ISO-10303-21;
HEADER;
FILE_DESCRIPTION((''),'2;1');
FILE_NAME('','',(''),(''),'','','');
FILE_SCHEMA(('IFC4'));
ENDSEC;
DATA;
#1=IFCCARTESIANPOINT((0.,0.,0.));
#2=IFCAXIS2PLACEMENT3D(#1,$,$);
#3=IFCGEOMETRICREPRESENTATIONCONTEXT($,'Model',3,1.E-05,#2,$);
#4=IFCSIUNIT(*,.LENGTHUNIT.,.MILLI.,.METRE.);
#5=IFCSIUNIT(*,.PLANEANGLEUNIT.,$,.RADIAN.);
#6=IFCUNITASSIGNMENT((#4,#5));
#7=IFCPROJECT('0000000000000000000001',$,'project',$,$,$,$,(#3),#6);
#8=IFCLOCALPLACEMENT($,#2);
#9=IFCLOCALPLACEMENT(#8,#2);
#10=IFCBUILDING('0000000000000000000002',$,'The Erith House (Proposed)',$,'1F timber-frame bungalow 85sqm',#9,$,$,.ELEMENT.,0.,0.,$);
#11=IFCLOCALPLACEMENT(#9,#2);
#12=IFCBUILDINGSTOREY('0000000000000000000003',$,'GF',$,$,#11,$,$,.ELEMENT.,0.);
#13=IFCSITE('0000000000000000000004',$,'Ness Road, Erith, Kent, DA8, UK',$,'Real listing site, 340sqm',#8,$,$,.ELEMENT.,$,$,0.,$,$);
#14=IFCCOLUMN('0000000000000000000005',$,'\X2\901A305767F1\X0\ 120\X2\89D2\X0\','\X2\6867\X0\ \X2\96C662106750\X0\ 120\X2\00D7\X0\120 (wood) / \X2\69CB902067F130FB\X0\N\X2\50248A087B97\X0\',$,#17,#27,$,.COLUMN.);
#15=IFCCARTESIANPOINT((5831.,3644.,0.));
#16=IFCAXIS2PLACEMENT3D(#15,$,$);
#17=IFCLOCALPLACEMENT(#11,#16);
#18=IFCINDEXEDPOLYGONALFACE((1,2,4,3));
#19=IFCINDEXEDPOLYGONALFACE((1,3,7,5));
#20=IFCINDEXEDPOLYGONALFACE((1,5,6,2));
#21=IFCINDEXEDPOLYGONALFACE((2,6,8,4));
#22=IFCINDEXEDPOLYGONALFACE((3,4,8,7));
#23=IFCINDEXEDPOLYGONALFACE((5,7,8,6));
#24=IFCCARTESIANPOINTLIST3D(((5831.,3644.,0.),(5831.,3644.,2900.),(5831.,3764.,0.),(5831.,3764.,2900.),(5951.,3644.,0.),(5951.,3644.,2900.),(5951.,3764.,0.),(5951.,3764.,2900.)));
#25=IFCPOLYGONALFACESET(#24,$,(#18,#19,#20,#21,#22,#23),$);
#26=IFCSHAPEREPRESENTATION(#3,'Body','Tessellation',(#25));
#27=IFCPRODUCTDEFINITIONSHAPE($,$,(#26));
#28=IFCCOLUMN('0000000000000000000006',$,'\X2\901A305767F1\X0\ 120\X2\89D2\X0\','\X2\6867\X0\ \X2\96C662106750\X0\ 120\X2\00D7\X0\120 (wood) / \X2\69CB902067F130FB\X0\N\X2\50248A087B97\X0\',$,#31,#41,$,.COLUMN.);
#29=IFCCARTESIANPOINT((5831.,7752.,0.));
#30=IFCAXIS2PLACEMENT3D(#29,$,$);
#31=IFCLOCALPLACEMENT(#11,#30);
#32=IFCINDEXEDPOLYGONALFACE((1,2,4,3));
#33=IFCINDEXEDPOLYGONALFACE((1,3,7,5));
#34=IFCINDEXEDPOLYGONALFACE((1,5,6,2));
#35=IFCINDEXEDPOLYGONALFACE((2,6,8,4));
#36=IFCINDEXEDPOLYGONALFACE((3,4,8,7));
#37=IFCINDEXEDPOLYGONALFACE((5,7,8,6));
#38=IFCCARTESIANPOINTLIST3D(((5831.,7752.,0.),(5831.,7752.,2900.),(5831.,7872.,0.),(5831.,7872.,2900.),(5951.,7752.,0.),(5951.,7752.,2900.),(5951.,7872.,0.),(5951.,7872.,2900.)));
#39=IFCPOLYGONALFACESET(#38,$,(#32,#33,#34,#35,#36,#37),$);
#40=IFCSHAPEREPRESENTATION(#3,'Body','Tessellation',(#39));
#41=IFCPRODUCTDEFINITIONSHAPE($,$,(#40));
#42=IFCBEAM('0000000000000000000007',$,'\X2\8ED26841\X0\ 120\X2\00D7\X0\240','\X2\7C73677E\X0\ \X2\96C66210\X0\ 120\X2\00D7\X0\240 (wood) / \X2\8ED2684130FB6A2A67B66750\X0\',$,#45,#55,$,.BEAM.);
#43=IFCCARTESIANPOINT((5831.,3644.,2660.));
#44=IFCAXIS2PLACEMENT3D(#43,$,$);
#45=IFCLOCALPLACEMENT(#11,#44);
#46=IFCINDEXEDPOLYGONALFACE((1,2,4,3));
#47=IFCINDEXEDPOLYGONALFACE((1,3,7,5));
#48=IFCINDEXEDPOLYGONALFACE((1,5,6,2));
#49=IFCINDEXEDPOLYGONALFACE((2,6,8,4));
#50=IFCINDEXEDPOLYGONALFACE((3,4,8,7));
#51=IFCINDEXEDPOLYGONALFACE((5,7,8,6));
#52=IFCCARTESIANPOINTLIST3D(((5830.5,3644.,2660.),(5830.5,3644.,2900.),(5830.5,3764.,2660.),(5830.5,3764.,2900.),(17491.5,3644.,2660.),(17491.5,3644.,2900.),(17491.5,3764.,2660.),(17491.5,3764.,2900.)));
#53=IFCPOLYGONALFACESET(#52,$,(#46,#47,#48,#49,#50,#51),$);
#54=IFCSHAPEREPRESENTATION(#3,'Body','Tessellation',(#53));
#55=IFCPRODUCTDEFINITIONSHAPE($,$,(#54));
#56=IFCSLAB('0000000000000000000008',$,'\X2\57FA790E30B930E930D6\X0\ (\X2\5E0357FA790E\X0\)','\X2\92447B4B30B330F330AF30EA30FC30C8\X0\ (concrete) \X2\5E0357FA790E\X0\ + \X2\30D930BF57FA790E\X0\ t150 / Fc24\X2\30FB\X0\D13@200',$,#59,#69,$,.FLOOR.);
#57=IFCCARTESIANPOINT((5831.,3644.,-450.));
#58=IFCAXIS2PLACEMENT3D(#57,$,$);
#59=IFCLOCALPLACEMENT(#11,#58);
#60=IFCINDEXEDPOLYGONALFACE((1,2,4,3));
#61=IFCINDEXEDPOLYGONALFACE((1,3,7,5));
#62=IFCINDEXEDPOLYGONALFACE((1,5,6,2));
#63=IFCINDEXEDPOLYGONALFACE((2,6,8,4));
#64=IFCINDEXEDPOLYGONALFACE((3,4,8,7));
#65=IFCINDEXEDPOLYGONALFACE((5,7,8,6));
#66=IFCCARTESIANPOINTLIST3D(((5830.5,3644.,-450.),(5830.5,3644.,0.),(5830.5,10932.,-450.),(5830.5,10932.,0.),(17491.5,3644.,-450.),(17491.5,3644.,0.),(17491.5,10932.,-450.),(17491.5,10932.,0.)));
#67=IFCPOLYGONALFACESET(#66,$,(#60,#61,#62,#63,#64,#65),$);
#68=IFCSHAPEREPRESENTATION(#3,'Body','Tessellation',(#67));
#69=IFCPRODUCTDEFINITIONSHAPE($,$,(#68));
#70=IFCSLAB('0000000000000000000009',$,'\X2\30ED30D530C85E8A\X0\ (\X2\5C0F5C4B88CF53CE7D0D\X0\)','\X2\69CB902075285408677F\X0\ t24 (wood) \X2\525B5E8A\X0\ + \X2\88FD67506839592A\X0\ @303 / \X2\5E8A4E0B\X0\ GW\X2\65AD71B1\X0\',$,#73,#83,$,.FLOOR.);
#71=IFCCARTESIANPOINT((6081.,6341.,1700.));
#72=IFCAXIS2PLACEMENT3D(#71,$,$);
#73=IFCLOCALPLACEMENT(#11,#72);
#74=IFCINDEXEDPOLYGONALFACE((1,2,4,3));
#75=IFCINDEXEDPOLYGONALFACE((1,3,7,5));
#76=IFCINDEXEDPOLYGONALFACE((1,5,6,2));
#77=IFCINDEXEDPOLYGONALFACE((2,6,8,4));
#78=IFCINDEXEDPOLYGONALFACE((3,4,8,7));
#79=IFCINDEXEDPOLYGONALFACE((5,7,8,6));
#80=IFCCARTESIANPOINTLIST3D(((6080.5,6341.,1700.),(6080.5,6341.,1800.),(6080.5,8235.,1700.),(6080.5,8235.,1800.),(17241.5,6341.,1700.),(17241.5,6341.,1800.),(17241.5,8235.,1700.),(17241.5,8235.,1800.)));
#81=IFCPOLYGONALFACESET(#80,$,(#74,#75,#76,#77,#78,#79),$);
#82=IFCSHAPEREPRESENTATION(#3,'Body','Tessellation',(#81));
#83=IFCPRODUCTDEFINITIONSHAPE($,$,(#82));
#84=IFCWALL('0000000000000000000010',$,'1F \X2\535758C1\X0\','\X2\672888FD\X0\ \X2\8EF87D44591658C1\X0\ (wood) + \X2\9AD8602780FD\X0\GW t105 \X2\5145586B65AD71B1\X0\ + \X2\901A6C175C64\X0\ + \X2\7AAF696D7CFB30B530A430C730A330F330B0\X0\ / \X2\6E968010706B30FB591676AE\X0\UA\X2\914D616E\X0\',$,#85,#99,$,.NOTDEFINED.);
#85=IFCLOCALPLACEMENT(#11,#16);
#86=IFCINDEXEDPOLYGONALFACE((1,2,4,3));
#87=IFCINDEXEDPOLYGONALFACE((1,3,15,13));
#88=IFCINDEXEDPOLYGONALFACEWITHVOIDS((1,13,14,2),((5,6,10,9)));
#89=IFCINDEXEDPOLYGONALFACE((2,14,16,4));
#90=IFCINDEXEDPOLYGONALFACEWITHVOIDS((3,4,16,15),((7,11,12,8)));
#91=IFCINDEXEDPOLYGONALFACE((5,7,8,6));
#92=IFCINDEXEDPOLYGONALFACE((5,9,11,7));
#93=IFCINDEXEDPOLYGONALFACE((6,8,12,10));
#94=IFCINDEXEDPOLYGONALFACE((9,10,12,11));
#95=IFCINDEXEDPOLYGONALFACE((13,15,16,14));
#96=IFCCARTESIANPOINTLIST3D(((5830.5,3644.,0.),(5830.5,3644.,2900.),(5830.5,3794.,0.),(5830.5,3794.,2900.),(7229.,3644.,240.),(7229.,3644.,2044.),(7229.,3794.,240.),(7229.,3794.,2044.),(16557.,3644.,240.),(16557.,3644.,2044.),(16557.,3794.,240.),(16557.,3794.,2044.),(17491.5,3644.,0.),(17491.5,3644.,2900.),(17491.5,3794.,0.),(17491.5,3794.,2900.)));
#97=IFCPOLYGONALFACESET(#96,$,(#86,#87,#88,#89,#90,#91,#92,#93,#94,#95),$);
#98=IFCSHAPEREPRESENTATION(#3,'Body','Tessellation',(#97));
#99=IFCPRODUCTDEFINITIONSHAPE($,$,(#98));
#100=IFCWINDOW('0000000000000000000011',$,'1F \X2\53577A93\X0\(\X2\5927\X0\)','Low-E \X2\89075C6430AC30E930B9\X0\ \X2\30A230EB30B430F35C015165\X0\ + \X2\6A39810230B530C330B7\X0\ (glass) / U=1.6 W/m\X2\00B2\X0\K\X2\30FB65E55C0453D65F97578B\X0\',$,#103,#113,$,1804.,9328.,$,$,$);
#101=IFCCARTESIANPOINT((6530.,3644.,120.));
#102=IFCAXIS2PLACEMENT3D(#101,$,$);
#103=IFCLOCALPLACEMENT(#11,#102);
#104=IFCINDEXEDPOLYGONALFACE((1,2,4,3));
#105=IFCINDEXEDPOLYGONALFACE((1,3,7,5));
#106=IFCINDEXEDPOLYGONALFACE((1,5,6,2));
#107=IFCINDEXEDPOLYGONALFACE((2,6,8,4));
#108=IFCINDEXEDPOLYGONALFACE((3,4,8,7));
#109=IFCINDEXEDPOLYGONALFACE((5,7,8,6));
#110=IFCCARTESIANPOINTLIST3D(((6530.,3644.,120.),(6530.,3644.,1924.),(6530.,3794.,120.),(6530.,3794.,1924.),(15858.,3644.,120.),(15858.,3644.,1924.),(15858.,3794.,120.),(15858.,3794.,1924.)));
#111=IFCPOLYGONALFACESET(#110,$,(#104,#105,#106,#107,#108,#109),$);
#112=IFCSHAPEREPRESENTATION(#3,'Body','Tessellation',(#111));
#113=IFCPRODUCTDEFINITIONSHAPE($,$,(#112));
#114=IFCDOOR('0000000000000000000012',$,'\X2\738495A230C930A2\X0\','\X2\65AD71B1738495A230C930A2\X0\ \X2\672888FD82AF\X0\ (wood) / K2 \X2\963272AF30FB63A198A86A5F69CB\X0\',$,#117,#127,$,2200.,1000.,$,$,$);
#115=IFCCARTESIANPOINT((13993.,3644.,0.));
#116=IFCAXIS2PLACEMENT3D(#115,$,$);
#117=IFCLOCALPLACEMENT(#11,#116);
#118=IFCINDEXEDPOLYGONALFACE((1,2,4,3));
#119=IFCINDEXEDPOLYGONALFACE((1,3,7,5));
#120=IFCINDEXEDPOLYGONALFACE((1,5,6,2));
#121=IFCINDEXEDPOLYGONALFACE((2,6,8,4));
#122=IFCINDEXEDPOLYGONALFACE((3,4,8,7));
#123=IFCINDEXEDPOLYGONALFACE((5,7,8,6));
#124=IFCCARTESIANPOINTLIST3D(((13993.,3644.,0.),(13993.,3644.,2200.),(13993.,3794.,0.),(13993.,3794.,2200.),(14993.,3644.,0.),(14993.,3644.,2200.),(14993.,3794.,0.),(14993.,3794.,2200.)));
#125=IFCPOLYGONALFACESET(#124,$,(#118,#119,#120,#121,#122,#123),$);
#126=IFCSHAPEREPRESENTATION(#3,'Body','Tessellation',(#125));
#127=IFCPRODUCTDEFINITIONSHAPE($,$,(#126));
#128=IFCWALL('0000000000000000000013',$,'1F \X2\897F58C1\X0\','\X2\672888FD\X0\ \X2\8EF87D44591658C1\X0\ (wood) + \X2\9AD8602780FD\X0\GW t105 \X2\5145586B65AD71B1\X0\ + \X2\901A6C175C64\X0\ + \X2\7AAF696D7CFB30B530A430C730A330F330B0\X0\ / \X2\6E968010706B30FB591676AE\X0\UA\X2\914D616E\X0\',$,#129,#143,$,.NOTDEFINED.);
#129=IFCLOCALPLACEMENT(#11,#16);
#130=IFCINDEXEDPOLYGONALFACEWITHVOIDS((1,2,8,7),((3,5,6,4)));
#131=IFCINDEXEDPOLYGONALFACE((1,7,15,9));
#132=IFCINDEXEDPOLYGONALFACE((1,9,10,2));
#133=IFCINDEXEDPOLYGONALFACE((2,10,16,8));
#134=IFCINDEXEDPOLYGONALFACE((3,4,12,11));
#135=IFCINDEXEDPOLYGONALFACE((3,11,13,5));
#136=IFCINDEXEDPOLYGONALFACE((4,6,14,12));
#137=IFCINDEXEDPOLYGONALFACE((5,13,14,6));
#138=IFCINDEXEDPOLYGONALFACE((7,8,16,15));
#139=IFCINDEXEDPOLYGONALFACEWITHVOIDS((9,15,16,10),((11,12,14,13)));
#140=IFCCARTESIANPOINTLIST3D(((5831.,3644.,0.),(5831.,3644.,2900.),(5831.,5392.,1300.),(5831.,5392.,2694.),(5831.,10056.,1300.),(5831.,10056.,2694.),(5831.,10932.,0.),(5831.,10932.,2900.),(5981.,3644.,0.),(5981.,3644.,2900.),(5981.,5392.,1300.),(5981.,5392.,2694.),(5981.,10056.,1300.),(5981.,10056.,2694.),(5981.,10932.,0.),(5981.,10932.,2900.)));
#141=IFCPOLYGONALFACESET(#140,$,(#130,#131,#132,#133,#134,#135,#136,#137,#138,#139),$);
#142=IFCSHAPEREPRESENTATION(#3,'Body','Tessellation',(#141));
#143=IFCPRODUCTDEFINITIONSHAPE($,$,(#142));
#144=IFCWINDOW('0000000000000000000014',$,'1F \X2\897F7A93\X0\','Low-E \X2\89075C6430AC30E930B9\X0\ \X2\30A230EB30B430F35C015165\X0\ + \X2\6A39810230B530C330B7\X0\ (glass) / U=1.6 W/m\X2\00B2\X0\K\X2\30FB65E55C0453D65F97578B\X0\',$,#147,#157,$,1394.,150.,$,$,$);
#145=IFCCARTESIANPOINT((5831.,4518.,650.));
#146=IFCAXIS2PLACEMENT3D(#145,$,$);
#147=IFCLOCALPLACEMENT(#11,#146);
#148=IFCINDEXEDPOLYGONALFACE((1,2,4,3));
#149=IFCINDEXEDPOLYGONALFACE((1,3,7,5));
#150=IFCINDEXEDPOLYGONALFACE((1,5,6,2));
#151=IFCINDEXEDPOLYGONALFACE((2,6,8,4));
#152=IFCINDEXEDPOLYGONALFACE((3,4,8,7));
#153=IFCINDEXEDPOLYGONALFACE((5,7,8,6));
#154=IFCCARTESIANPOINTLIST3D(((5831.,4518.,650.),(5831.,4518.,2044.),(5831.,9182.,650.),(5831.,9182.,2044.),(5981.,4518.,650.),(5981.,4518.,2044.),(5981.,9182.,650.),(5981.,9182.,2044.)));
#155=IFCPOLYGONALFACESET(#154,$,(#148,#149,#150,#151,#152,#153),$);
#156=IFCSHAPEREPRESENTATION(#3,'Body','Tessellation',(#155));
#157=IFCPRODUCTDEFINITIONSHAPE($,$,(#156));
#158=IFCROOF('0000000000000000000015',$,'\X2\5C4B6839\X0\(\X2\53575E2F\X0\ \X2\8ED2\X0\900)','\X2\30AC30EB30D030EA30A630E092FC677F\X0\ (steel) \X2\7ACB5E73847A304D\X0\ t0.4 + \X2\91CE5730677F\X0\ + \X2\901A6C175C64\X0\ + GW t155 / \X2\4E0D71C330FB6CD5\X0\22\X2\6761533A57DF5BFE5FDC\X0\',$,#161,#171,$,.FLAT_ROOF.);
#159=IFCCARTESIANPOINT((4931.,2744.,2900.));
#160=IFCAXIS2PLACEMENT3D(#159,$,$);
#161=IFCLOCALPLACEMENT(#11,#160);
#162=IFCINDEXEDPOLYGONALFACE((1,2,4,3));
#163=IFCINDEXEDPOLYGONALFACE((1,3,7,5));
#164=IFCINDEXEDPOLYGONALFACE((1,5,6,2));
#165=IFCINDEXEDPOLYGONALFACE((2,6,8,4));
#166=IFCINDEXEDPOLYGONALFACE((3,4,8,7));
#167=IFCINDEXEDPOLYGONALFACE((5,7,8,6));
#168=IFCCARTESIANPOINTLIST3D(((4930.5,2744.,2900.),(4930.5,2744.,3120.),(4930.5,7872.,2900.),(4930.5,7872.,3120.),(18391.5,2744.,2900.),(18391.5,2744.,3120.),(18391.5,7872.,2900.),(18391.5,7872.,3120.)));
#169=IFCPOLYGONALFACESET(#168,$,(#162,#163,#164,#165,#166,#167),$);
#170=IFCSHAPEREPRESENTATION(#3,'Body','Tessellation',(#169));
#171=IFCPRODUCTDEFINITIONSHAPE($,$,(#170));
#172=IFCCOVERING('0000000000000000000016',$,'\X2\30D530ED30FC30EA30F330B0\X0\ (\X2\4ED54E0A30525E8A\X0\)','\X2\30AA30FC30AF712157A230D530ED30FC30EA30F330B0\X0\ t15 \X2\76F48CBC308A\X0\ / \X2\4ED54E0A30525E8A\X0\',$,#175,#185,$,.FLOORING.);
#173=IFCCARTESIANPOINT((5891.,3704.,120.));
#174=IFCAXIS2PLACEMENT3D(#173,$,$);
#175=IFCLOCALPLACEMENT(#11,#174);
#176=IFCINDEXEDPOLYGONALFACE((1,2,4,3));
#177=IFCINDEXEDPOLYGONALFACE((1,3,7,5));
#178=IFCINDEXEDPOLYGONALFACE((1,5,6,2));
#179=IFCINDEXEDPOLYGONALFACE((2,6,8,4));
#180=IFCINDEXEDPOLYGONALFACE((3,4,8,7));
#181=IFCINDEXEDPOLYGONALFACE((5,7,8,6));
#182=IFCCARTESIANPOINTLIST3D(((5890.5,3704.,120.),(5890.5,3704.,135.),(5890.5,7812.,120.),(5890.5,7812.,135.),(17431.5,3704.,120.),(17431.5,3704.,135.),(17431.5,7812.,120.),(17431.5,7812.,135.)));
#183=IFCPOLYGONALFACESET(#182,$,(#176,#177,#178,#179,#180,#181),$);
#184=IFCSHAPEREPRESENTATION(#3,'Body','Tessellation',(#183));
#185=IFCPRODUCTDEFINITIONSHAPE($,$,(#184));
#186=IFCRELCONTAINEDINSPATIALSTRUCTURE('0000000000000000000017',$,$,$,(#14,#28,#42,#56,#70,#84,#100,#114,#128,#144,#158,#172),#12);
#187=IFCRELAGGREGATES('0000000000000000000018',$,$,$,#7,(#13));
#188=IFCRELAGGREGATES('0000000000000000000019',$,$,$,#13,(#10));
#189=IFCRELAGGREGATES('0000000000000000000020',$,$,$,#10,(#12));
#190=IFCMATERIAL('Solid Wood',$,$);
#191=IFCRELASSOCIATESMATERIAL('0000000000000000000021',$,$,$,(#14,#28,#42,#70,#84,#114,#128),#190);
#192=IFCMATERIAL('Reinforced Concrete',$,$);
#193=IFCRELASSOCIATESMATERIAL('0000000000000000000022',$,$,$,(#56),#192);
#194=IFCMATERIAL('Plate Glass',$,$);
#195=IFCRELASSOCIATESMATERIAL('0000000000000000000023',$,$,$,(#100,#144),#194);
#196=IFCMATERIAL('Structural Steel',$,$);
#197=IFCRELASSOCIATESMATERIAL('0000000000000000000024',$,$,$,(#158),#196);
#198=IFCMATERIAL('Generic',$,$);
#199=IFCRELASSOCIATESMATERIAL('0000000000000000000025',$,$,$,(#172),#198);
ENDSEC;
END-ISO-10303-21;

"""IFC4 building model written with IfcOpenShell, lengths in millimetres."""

from ifc_helpers import new_model, si_unit, frame, frame_2d, origin, place, context, project, spatial, rectangle, extrude, material, element, fill, save


model = new_model("IFC4")

# Units and contexts
model_context = context("Model", 3, precision=1e-05, world=origin())
ifc_project = project(units=[si_unit("LENGTHUNIT", "METRE", prefix="MILLI"), si_unit("PLANEANGLEUNIT", "RADIAN")], contexts=[model_context])

# Site, building, storey
site_placement = place(None, origin())
site = spatial("IfcSite", under=ifc_project, at=site_placement, Name="Ness Road, Erith, Kent, DA8, UK", ObjectType="Real listing site, 340sqm", CompositionType="ELEMENT", RefElevation=0.0)
building_placement = place(site_placement, origin())
building = spatial("IfcBuilding", under=site, at=building_placement, Name="The Erith House (Proposed)", ObjectType="1F timber-frame bungalow 85sqm", CompositionType="ELEMENT", ElevationOfRefHeight=0.0, ElevationOfTerrain=0.0)
storey_placement = place(building_placement, origin())
storey = spatial("IfcBuildingStorey", under=building, at=storey_placement, Name="GF", CompositionType="ELEMENT", Elevation=0.0)

# Columns
ifc_material_1 = material(Name="Solid Wood")
column_1_placement = place(storey_placement, frame((5831.0, 3644.0, 0.0)))
element("IfcColumn", 1, at=column_1_placement, inside=storey, material=ifc_material_1, Name="通し柱 120角", Description="桧 集成材 120×120 (wood) / 構造柱・N値計算", PredefinedType="COLUMN", context=model_context, shape_type="SweptSolid", body=[
    extrude(rectangle(XDim=120.0, YDim=120.0, at=frame_2d((60.0, 60.0))), frame((5831.0, 3644.0, 0.0)), (0.0, 0.0, 1.0), 2900.0),
])
column_2_placement = place(storey_placement, frame((5831.0, 7752.0, 0.0)))
element("IfcColumn", 2, at=column_2_placement, inside=storey, material=ifc_material_1, Name="通し柱 120角", Description="桧 集成材 120×120 (wood) / 構造柱・N値計算", PredefinedType="COLUMN", context=model_context, shape_type="SweptSolid", body=[
    extrude(rectangle(XDim=120.0, YDim=120.0, at=frame_2d((60.0, 60.0))), frame((5831.0, 7752.0, 0.0)), (0.0, 0.0, 1.0), 2900.0),
])

# Beam
beam_1_placement = place(storey_placement, frame((5831.0, 3644.0, 2660.0)))
element("IfcBeam", 3, at=beam_1_placement, inside=storey, material=ifc_material_1, Name="軒桁 120×240", Description="米松 集成 120×240 (wood) / 軒桁・横架材", PredefinedType="BEAM", context=model_context, shape_type="SweptSolid", body=[
    extrude(rectangle(XDim=11661.0, YDim=120.0, at=frame_2d((5830.0, 60.0))), frame((5831.0, 3644.0, 2660.0)), (0.0, 0.0, 1.0), 240.0),
])

# Slabs
ifc_material_2 = material(Name="Reinforced Concrete")
slab_1_placement = place(storey_placement, frame((5831.0, 3644.0, -450.0)))
element("IfcSlab", 4, at=slab_1_placement, inside=storey, material=ifc_material_2, Name="基礎スラブ (布基礎)", Description="鉄筋コンクリート (concrete) 布基礎 + ベタ基礎 t150 / Fc24・D13@200", PredefinedType="FLOOR", context=model_context, shape_type="SweptSolid", body=[
    extrude(rectangle(XDim=11661.0, YDim=7288.0, at=frame_2d((5830.0, 3644.0))), frame((5831.0, 3644.0, -450.0)), (0.0, 0.0, 1.0), 450.0),
])
slab_2_placement = place(storey_placement, frame((6081.0, 6341.0, 1700.0)))
element("IfcSlab", 5, at=slab_2_placement, inside=storey, material=ifc_material_1, Name="ロフト床 (小屋裏収納)", Description="構造用合板 t24 (wood) 剛床 + 製材根太 @303 / 床下 GW断熱", PredefinedType="FLOOR", context=model_context, shape_type="SweptSolid", body=[
    extrude(rectangle(XDim=11161.0, YDim=1894.0, at=frame_2d((5580.0, 947.0))), frame((6081.0, 6341.0, 1700.0)), (0.0, 0.0, 1.0), 100.0),
])

# Wall, openings, window, door
wall_1_placement = place(storey_placement, frame((5831.0, 3644.0, 0.0)))
wall_1 = element("IfcWall", 6, at=wall_1_placement, inside=storey, material=ifc_material_1, Name="1F 南壁", Description="木製 軸組外壁 (wood) + 高性能GW t105 充填断熱 + 通気層 + 窯業系サイディング / 準耐火・外皮UA配慮", PredefinedType="NOTDEFINED", context=model_context, shape_type="SweptSolid", body=[
    extrude(rectangle(XDim=11661.0, YDim=150.0, at=frame_2d((5830.0, 75.0))), frame((5831.0, 3644.0, 0.0)), (0.0, 0.0, 1.0), 2900.0),
])
opening_1_placement = place(storey_placement, frame((6530.0, 3644.0, 120.0)))
opening_1 = element("IfcOpeningElement", 7, at=opening_1_placement, cuts=wall_1, PredefinedType="NOTDEFINED", context=model_context, shape_type="SweptSolid", body=[
    extrude(rectangle(XDim=9328.0, YDim=150.0, at=frame_2d((4664.0, 75.0))), frame((6530.0, 3644.0, 120.0)), (0.0, 0.0, 1.0), 1804.0),
])
opening_2_placement = place(storey_placement, frame((13993.0, 3644.0, 0.0)))
opening_2 = element("IfcOpeningElement", 8, at=opening_2_placement, cuts=wall_1, PredefinedType="NOTDEFINED", context=model_context, shape_type="SweptSolid", body=[
    extrude(rectangle(XDim=1000.0, YDim=150.0, at=frame_2d((500.0, 75.0))), frame((13993.0, 3644.0, 0.0)), (0.0, 0.0, 1.0), 2200.0),
])
ifc_material_3 = material(Name="Plate Glass")
window_1_placement = place(storey_placement, frame((6530.0, 3644.0, 120.0)))
window_1 = element("IfcWindow", 9, at=window_1_placement, inside=storey, material=ifc_material_3, Name="1F 南窓(大)", Description="Low-E 複層ガラス アルゴン封入 + 樹脂サッシ (glass) / U=1.6 W/m²K・日射取得型", OverallHeight=1804.0, OverallWidth=9328.0, context=model_context, shape_type="SweptSolid", body=[
    extrude(rectangle(XDim=9328.0, YDim=150.0, at=frame_2d((4664.0, 75.0))), frame((6530.0, 3644.0, 120.0)), (0.0, 0.0, 1.0), 1804.0),
])
fill(opening_1, window_1)
door_placement = place(storey_placement, frame((13993.0, 3644.0, 0.0)))
door = element("IfcDoor", 10, at=door_placement, inside=storey, material=ifc_material_1, Name="玄関ドア", Description="断熱玄関ドア 木製芯 (wood) / K2 防犯・採風機構", OverallHeight=2200.0, OverallWidth=1000.0, context=model_context, shape_type="SweptSolid", body=[
    extrude(rectangle(XDim=1000.0, YDim=150.0, at=frame_2d((500.0, 75.0))), frame((13993.0, 3644.0, 0.0)), (0.0, 0.0, 1.0), 2200.0),
])
fill(opening_2, door)

# Wall, opening, window
wall_2_placement = place(storey_placement, frame((5831.0, 3644.0, 0.0)))
wall_2 = element("IfcWall", 11, at=wall_2_placement, inside=storey, material=ifc_material_1, Name="1F 西壁", Description="木製 軸組外壁 (wood) + 高性能GW t105 充填断熱 + 通気層 + 窯業系サイディング / 準耐火・外皮UA配慮", PredefinedType="NOTDEFINED", context=model_context, shape_type="SweptSolid", body=[
    extrude(rectangle(XDim=150.0, YDim=7288.0, at=frame_2d((75.0, 3644.0))), frame((5831.0, 3644.0, 0.0)), (0.0, 0.0, 1.0), 2900.0),
])
opening_3_placement = place(storey_placement, frame((5831.0, 4518.0, 650.0)))
opening_3 = element("IfcOpeningElement", 12, at=opening_3_placement, cuts=wall_2, PredefinedType="NOTDEFINED", context=model_context, shape_type="SweptSolid", body=[
    extrude(rectangle(XDim=150.0, YDim=4664.0, at=frame_2d((75.0, 2332.0))), frame((5831.0, 4518.0, 650.0)), (0.0, 0.0, 1.0), 1394.0),
])
window_2_placement = place(storey_placement, frame((5831.0, 4518.0, 650.0)))
window_2 = element("IfcWindow", 13, at=window_2_placement, inside=storey, material=ifc_material_3, Name="1F 西窓", Description="Low-E 複層ガラス アルゴン封入 + 樹脂サッシ (glass) / U=1.6 W/m²K・日射取得型", OverallHeight=1394.0, OverallWidth=150.0, context=model_context, shape_type="SweptSolid", body=[
    extrude(rectangle(XDim=150.0, YDim=4664.0, at=frame_2d((75.0, 2332.0))), frame((5831.0, 4518.0, 650.0)), (0.0, 0.0, 1.0), 1394.0),
])
fill(opening_3, window_2)

# Roof
ifc_material_4 = material(Name="Structural Steel")
roof_placement = place(storey_placement, frame((4931.0, 2744.0, 2900.0)))
element("IfcRoof", 14, at=roof_placement, inside=storey, material=ifc_material_4, Name="屋根(南帯 軒900)", Description="ガルバリウム鋼板 (steel) 立平葺き t0.4 + 野地板 + 通気層 + GW t155 / 不燃・法22条区域対応", PredefinedType="FLAT_ROOF", context=model_context, shape_type="SweptSolid", body=[
    extrude(rectangle(XDim=13461.0, YDim=5128.0, at=frame_2d((6730.0, 2564.0))), frame((4931.0, 2744.0, 2900.0)), (0.0, 0.0, 1.0), 220.0),
])

# Covering
ifc_material_5 = material(Name="Generic")
covering_1_placement = place(storey_placement, frame((5891.0, 3704.0, 120.0)))
element("IfcCovering", 15, at=covering_1_placement, inside=storey, material=ifc_material_5, Name="フローリング (仕上げ床)", Description="オーク無垢フローリング t15 直貼り / 仕上げ床", PredefinedType="FLOORING", context=model_context, shape_type="SweptSolid", body=[
    extrude(rectangle(XDim=11541.0, YDim=4108.0, at=frame_2d((5770.0, 2054.0))), frame((5891.0, 3704.0, 120.0)), (0.0, 0.0, 1.0), 15.0),
])

save(model, "model.ifc")
